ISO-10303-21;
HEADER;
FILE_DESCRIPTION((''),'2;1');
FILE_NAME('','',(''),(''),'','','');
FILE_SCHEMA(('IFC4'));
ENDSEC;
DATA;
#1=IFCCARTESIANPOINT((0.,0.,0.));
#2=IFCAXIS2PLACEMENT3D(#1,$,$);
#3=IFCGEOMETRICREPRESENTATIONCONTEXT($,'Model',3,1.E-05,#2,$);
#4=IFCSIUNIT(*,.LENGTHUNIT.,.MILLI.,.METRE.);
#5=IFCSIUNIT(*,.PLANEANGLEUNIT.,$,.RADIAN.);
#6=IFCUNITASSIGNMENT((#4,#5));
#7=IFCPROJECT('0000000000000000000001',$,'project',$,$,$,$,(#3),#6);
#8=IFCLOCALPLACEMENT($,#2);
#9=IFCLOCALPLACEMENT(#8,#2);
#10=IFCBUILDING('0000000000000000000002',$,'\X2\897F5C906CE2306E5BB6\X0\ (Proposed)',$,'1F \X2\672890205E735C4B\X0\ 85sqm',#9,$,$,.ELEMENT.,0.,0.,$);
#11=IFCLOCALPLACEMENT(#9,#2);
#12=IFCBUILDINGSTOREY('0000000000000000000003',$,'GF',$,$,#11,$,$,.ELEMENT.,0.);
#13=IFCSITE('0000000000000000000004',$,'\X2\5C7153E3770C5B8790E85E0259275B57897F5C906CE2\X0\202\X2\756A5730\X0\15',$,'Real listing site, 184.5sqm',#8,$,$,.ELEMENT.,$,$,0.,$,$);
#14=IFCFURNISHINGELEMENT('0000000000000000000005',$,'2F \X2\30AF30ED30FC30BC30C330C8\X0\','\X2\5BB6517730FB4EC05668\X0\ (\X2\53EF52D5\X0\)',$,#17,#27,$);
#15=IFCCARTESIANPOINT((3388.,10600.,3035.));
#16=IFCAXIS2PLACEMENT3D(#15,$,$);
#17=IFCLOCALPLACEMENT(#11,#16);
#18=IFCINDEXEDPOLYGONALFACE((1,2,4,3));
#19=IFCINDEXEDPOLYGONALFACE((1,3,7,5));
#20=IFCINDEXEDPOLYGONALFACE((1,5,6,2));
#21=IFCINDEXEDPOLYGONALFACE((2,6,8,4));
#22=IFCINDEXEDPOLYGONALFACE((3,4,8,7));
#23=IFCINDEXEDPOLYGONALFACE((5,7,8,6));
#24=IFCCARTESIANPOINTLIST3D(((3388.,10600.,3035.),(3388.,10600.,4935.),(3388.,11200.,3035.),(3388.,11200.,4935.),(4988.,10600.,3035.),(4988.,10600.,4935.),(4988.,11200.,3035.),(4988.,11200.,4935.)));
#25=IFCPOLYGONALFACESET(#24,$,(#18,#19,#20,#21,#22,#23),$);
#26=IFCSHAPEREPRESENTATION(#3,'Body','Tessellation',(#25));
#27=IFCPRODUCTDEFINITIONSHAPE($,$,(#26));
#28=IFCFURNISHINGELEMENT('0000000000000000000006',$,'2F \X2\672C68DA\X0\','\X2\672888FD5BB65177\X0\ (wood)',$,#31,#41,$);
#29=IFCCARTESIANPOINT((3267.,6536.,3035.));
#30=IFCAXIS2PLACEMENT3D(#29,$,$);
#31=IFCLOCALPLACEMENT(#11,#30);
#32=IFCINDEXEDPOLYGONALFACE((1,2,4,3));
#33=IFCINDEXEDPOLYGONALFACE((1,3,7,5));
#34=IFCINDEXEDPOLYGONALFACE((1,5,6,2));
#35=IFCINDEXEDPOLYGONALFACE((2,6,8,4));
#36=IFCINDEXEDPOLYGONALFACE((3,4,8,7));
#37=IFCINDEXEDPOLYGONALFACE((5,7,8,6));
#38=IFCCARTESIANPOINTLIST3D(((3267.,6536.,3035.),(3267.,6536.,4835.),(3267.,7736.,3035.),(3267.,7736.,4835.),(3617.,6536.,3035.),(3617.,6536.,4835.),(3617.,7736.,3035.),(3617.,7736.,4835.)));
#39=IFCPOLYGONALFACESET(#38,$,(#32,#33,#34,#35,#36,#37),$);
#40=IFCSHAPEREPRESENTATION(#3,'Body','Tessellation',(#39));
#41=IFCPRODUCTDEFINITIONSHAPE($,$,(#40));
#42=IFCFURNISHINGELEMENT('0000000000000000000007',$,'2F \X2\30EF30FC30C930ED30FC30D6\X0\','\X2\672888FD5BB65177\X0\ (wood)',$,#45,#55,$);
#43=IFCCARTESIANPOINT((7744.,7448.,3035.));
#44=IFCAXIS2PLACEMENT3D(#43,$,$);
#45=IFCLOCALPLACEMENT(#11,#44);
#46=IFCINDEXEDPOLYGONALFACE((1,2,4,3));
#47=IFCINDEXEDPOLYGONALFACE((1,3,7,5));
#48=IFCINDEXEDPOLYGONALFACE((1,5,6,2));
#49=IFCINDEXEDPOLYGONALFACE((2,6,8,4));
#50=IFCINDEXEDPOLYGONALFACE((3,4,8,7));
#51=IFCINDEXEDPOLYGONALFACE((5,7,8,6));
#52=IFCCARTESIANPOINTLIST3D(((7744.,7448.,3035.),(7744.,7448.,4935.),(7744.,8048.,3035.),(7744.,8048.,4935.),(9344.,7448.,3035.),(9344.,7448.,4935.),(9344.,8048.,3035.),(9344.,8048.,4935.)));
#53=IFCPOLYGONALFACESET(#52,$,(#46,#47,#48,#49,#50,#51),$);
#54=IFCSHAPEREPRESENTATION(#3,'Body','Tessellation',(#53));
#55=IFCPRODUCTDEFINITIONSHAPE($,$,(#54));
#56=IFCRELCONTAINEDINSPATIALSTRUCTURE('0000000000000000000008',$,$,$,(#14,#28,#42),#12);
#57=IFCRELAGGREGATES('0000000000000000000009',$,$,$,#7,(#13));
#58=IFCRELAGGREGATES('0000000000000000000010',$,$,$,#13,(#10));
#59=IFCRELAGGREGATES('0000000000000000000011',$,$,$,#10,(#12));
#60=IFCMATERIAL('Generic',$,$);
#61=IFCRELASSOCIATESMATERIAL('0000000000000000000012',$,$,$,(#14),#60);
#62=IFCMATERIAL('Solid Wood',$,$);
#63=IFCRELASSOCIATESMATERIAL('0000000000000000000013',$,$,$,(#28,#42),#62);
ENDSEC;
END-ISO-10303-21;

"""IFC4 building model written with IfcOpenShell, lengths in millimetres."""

from ifc_helpers import new_model, si_unit, frame, frame_2d, origin, place, context, project, spatial, rectangle, extrude, material, element, save


model = new_model("IFC4")

# Units and contexts
model_context = context("Model", 3, precision=1e-05, world=origin())
ifc_project = project(units=[si_unit("LENGTHUNIT", "METRE", prefix="MILLI"), si_unit("PLANEANGLEUNIT", "RADIAN")], contexts=[model_context])

# Site, building, storey
site_placement = place(None, origin())
site = spatial("IfcSite", under=ifc_project, at=site_placement, Name="山口県宇部市大字西岐波202番地15", ObjectType="Real listing site, 184.5sqm", CompositionType="ELEMENT", RefElevation=0.0)
building_placement = place(site_placement, origin())
building = spatial("IfcBuilding", under=site, at=building_placement, Name="西岐波の家 (Proposed)", ObjectType="1F 木造平屋 85sqm", CompositionType="ELEMENT", ElevationOfRefHeight=0.0, ElevationOfTerrain=0.0)
storey_placement = place(building_placement, origin())
storey = spatial("IfcBuildingStorey", under=building, at=storey_placement, Name="GF", CompositionType="ELEMENT", Elevation=0.0)

# Shared definitions
ifc_material_1 = material(Name="Solid Wood")

# Shared definitions
ifc_material_2 = material(Name="Generic")

# Furnishing elements
furnishing_1_placement = place(storey_placement, frame((3388.0, 10600.0, 3035.0)))
element("IfcFurnishingElement", 1, at=furnishing_1_placement, inside=storey, material=ifc_material_2, Name="2F クローゼット", Description="家具・什器 (可動)", context=model_context, shape_type="SweptSolid", body=[
    extrude(rectangle(XDim=1600.0, YDim=600.0, at=frame_2d((800.0, 300.0))), frame((3388.0, 10600.0, 3035.0)), (0.0, 0.0, 1.0), 1900.0),
])
furnishing_2_placement = place(storey_placement, frame((3267.0, 6536.0, 3035.0)))
element("IfcFurnishingElement", 2, at=furnishing_2_placement, inside=storey, material=ifc_material_1, Name="2F 本棚", Description="木製家具 (wood)", context=model_context, shape_type="SweptSolid", body=[
    extrude(rectangle(XDim=350.0, YDim=1200.0, at=frame_2d((175.0, 600.0))), frame((3267.0, 6536.0, 3035.0)), (0.0, 0.0, 1.0), 1800.0),
])
furnishing_3_placement = place(storey_placement, frame((7744.0, 7448.0, 3035.0)))
element("IfcFurnishingElement", 3, at=furnishing_3_placement, inside=storey, material=ifc_material_1, Name="2F ワードローブ", Description="木製家具 (wood)", context=model_context, shape_type="SweptSolid", body=[
    extrude(rectangle(XDim=1600.0, YDim=600.0, at=frame_2d((800.0, 300.0))), frame((7744.0, 7448.0, 3035.0)), (0.0, 0.0, 1.0), 1900.0),
])

save(model, "model.ifc")
